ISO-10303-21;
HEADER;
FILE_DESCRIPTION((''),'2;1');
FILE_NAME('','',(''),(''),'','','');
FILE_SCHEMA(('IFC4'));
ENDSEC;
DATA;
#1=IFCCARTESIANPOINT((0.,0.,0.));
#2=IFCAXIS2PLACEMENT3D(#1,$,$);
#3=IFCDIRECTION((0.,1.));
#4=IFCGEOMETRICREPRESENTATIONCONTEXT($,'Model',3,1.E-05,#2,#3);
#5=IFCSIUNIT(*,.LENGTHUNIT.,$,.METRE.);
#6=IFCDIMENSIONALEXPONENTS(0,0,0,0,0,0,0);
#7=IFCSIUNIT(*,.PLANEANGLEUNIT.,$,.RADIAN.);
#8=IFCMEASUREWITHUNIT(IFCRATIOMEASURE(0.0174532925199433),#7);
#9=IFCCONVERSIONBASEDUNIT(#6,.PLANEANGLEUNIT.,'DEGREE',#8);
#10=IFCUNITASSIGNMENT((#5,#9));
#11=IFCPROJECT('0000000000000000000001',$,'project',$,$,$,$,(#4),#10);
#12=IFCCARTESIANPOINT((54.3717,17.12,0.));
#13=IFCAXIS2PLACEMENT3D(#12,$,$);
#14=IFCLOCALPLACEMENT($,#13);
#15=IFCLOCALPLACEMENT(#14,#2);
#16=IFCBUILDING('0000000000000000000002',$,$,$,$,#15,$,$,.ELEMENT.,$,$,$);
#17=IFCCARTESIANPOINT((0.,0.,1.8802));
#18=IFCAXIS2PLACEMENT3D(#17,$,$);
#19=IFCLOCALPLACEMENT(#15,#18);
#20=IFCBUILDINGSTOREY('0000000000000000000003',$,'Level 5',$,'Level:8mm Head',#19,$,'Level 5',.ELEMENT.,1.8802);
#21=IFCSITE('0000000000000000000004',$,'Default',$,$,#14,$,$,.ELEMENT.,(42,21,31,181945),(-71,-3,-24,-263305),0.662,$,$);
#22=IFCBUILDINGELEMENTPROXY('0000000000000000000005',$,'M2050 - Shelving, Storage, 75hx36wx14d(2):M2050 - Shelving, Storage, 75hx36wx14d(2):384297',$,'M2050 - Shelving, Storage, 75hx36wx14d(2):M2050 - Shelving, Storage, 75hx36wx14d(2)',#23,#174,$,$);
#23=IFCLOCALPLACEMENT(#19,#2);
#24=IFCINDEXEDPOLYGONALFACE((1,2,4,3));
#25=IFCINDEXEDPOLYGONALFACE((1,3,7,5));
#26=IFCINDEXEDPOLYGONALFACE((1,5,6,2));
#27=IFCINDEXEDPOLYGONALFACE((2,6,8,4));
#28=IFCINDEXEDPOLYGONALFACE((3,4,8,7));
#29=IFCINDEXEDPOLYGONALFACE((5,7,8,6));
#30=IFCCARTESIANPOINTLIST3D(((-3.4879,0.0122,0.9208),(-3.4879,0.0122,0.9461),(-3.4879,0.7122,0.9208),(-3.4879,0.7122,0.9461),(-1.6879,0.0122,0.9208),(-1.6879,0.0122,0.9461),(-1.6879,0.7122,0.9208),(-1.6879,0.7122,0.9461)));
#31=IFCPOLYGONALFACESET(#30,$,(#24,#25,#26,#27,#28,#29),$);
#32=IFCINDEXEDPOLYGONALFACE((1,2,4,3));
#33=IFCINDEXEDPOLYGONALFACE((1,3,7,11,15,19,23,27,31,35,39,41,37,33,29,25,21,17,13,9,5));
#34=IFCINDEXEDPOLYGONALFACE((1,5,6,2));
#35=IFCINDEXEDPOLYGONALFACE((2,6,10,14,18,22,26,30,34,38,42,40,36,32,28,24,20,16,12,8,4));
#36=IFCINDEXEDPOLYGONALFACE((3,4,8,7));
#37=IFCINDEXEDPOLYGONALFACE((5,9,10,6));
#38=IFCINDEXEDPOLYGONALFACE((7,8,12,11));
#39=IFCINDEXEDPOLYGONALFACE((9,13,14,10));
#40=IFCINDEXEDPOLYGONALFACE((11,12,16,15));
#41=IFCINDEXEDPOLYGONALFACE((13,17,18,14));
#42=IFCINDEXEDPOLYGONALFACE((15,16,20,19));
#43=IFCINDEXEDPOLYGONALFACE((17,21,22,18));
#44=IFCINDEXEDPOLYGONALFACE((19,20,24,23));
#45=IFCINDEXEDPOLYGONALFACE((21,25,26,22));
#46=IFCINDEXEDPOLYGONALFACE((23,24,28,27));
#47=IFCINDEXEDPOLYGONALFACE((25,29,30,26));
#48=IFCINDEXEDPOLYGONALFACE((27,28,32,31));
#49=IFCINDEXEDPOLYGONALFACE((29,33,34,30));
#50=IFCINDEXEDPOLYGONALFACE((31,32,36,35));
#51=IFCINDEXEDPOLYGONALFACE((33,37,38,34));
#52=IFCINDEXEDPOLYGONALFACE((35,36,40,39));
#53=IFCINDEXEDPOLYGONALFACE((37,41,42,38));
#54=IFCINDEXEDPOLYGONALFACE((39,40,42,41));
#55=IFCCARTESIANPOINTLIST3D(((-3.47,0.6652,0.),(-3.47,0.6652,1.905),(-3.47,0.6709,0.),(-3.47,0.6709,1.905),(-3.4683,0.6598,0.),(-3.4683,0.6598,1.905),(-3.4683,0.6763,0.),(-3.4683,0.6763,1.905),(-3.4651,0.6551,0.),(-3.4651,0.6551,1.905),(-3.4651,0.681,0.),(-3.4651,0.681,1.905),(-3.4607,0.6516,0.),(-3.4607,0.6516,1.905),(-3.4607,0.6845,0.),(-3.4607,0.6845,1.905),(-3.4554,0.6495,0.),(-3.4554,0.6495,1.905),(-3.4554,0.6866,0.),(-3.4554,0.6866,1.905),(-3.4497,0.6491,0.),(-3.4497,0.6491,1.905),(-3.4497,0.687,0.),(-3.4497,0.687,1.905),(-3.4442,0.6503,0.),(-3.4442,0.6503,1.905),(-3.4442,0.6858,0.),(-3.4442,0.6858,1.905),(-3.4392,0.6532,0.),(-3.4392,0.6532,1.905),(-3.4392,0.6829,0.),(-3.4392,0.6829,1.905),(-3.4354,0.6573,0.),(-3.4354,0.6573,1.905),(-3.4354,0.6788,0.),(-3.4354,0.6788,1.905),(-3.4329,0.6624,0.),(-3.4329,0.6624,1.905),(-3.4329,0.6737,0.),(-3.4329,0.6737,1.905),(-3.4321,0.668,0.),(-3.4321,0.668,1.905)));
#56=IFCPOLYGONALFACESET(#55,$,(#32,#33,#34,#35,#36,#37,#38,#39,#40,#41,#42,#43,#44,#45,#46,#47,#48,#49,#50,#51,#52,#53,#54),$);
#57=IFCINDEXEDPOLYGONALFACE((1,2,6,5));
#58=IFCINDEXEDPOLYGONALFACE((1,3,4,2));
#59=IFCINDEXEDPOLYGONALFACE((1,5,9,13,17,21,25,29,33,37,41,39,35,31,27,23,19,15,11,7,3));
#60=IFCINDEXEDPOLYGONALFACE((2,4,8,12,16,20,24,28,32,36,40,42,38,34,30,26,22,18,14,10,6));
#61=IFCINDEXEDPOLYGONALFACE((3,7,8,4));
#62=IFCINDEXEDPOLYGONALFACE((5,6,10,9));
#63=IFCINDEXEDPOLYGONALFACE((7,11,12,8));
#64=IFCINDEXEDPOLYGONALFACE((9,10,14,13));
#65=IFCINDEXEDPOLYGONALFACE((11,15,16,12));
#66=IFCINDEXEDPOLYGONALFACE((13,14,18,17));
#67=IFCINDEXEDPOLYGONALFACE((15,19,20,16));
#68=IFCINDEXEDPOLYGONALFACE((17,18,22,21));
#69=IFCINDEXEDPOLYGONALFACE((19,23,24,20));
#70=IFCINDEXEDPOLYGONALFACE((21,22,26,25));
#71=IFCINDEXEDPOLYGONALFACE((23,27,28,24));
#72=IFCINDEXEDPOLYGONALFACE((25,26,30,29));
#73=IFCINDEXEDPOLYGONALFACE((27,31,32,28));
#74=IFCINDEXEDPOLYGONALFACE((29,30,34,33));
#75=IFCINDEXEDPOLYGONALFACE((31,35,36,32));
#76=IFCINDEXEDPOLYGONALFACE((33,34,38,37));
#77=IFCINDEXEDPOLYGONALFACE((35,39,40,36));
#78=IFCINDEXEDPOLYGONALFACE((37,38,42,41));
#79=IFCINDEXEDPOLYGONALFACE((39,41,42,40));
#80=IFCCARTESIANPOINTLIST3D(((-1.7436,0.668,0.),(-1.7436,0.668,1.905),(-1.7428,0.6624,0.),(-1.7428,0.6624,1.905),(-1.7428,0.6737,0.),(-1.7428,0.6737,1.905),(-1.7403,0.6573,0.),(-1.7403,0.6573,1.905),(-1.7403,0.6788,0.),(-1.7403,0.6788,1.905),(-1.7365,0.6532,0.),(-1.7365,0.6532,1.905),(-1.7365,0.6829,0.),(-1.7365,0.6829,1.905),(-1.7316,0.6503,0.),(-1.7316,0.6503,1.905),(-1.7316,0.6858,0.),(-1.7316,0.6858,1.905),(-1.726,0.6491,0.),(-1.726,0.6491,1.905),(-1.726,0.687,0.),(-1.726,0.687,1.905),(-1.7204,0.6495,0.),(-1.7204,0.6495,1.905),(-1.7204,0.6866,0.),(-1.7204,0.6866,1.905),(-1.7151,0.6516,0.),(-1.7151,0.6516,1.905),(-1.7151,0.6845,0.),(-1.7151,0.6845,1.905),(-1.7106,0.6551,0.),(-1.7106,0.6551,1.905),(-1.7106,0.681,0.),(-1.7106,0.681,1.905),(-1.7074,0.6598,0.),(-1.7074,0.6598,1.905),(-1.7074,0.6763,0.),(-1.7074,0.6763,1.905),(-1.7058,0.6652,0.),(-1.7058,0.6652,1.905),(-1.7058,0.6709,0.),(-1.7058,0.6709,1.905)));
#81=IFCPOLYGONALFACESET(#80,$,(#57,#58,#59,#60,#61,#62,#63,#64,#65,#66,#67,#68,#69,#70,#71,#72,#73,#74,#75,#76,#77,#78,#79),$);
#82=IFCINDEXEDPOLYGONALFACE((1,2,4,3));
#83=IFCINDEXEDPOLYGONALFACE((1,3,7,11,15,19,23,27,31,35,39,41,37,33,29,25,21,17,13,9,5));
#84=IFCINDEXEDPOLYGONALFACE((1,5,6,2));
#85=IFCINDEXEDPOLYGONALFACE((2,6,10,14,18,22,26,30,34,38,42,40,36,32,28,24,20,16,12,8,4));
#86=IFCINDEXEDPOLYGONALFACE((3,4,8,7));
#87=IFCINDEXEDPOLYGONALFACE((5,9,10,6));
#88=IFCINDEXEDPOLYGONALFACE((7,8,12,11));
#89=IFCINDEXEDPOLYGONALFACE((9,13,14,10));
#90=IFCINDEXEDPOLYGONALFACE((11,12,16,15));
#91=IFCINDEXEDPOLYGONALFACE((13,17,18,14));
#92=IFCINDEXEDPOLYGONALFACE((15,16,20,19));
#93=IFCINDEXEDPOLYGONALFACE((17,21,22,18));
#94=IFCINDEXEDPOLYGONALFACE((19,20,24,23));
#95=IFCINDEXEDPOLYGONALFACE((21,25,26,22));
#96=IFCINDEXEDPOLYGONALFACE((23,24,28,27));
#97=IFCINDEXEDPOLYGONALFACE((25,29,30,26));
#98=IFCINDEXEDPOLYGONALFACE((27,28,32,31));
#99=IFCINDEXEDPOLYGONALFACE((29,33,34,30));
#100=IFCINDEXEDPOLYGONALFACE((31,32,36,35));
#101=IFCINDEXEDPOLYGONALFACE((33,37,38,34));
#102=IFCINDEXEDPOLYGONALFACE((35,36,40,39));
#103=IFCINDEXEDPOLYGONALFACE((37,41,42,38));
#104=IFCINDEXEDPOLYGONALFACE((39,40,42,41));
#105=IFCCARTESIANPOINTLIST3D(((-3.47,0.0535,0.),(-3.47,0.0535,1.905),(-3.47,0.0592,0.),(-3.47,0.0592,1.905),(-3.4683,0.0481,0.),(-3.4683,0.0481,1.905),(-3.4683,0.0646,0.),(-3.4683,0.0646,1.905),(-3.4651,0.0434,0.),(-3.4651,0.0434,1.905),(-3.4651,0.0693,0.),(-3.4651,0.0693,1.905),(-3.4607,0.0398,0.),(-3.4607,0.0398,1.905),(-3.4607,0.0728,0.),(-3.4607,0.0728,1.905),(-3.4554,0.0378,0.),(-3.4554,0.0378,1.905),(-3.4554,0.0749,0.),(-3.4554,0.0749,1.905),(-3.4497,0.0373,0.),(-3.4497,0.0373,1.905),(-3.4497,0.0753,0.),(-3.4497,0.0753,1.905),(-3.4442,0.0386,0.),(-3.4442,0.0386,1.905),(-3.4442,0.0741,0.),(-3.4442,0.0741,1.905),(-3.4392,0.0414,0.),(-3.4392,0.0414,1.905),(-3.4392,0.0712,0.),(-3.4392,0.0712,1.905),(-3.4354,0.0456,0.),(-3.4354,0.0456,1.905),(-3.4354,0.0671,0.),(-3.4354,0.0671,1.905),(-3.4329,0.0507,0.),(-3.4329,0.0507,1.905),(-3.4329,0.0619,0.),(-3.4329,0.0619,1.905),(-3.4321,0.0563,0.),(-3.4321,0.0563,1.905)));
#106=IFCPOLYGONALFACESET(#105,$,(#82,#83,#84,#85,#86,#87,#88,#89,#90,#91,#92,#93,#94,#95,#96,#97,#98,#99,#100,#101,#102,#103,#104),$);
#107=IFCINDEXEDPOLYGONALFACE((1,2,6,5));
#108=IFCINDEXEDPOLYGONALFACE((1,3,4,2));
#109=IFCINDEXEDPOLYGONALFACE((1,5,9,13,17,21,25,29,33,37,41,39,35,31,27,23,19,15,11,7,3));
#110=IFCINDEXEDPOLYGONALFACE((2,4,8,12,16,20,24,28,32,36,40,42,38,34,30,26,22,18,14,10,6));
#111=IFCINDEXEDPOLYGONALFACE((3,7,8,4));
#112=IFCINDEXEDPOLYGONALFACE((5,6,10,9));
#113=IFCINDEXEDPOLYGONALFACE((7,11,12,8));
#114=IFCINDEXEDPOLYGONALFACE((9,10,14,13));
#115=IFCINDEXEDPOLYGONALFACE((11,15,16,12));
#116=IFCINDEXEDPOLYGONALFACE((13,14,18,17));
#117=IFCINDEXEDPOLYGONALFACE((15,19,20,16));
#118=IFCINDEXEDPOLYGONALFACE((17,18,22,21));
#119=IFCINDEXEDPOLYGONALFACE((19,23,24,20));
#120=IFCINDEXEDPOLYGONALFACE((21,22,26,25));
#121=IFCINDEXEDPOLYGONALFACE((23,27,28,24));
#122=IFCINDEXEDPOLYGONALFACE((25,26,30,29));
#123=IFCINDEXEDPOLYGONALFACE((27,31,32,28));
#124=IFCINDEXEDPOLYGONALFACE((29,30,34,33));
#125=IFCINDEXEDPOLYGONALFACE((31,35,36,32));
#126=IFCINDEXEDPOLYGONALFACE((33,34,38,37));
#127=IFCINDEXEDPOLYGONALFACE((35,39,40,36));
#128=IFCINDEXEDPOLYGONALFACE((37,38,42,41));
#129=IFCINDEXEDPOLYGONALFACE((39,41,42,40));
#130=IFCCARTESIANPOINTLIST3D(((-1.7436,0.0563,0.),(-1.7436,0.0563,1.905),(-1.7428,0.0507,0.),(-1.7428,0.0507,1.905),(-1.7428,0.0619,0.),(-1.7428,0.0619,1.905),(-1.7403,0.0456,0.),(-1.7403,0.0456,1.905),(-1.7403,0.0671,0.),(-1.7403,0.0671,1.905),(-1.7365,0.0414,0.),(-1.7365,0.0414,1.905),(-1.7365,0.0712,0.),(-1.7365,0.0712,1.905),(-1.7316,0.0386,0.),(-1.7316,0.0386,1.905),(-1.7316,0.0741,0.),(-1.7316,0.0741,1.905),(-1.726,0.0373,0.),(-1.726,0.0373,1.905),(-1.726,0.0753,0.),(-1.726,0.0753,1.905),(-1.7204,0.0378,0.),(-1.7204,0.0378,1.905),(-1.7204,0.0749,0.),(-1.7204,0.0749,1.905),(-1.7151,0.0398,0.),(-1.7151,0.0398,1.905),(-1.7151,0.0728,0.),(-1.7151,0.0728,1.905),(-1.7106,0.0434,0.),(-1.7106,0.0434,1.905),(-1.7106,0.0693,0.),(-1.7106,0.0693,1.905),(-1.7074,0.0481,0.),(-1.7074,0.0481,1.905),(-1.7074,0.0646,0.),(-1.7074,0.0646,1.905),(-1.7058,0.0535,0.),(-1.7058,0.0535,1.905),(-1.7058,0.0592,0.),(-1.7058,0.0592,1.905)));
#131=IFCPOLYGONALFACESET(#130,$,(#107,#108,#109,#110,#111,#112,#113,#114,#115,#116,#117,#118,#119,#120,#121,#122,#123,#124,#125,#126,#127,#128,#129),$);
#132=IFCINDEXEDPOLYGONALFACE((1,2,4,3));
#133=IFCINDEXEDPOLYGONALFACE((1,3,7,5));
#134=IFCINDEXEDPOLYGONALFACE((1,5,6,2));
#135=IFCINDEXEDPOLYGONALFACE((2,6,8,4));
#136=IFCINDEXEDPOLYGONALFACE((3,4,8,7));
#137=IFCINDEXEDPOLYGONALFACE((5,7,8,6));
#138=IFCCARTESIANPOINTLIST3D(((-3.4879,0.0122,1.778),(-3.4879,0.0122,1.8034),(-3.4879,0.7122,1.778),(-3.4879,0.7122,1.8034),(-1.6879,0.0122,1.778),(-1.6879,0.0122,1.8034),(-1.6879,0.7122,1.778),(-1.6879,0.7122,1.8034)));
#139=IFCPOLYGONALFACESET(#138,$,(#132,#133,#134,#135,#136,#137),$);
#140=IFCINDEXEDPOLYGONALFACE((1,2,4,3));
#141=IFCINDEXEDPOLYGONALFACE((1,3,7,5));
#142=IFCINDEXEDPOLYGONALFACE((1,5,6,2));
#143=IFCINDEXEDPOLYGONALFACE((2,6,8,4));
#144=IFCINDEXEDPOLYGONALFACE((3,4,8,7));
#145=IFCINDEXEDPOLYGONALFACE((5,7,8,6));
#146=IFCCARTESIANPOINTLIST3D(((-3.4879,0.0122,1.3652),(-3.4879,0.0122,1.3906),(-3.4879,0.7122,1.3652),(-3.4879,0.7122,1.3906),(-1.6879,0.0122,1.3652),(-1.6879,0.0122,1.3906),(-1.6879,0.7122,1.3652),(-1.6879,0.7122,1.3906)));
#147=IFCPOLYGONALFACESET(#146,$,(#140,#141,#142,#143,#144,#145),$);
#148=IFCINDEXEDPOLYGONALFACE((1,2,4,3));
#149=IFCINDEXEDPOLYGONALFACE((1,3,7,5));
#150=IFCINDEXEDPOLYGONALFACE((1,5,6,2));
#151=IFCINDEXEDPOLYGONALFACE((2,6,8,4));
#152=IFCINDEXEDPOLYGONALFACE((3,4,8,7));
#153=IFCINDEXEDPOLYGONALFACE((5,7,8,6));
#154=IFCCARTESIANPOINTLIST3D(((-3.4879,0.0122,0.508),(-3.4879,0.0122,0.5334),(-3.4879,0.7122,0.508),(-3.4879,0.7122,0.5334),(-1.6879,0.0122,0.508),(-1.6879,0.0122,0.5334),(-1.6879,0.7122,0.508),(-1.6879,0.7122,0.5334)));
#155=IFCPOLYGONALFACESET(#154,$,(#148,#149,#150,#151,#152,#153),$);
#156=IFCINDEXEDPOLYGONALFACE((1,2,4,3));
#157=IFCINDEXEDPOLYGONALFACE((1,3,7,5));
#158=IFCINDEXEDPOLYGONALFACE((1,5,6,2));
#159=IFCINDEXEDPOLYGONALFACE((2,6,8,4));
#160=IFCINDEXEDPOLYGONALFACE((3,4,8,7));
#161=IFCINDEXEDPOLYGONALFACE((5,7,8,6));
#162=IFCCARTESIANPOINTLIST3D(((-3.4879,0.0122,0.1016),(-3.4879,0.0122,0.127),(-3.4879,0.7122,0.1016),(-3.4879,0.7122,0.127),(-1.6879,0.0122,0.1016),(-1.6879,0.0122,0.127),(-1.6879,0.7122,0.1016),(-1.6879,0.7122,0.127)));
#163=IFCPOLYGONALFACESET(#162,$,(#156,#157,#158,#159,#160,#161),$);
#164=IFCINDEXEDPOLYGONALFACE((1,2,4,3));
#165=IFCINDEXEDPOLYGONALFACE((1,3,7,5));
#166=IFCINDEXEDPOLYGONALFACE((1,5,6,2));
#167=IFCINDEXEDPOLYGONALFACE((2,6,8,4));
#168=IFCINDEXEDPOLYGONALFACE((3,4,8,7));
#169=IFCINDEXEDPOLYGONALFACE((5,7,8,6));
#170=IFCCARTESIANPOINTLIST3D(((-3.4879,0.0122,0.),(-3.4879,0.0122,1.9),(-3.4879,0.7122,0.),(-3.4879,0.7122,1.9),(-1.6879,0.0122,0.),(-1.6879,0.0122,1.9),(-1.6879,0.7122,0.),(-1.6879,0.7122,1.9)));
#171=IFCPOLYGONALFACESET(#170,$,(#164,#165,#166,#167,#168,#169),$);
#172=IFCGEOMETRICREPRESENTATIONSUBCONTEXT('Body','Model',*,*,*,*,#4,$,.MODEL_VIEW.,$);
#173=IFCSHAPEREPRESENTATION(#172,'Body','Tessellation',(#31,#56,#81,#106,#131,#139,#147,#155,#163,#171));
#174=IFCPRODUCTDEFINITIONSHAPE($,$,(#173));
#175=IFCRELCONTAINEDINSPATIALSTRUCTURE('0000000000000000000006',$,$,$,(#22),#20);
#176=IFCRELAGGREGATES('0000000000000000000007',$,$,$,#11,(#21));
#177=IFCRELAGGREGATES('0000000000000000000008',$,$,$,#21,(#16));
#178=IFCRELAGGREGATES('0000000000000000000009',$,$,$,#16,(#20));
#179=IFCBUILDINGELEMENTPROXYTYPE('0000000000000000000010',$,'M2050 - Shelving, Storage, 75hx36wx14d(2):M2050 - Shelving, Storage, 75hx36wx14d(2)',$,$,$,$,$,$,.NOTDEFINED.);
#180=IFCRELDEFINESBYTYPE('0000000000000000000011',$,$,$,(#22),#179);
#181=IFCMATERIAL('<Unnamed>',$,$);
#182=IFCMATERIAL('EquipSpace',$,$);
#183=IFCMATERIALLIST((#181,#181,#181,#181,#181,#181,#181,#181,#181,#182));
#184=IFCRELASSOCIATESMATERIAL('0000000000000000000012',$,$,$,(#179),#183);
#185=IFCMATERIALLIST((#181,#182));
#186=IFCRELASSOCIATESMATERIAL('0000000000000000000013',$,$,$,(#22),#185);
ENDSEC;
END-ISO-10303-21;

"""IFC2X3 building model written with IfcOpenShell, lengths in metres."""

from ifc_helpers import new_model, entity, si_unit, converted_unit, direction, frame, frame_2d, origin, origin_2d_with_axis, place, context, subcontext, project, spatial, rectangle, circle, extrude, source, transform, mapped, material, material_list, type_object, type_shapes, element, save


model = new_model("IFC2X3")

# Units and contexts
model_context = context("Model", 3, precision=1e-05, world=origin(), true_north=direction((0.0, 1.0)))
body_context = subcontext(model_context, "Body", "Model", "MODEL_VIEW")
ifc_project = project(units=[si_unit("LENGTHUNIT", "METRE"), converted_unit("PLANEANGLEUNIT", "DEGREE", entity("IfcRatioMeasure", 0.0174532925199433), si_unit("PLANEANGLEUNIT", "RADIAN"), dimensions=[0, 0, 0, 0, 0, 0, 0])], contexts=[model_context])

# Site, building, storey
site_placement = place(None, frame((54.3717, 17.12, 0.0)))
site = spatial("IfcSite", under=ifc_project, at=site_placement, Name="Default", CompositionType="ELEMENT", RefLatitude=(42, 21, 31, 181945), RefLongitude=(-71, -3, -24, -263305), RefElevation=0.662)
building_placement = place(site_placement, origin())
building = spatial("IfcBuilding", under=site, at=building_placement, CompositionType="ELEMENT")
storey_placement = place(building_placement, frame((0.0, 0.0, 1.8802)))
storey = spatial("IfcBuildingStorey", under=building, at=storey_placement, Name="Level 5", ObjectType="Level:8mm Head", LongName="Level 5", CompositionType="ELEMENT", Elevation=1.8802)

# Building element proxy
ifc_material_1 = material(Name="<Unnamed>")
ifc_material_2 = material(Name="EquipSpace")
ifc_material_list_1 = material_list([ifc_material_1, ifc_material_1, ifc_material_1, ifc_material_1, ifc_material_1, ifc_material_1, ifc_material_1, ifc_material_1, ifc_material_1, ifc_material_2])
building_element_proxy_type = type_object("IfcBuildingElementProxyType", Name="M2050 - Shelving, Storage, 75hx36wx14d(2):M2050 - Shelving, Storage, 75hx36wx14d(2)", PredefinedType="NOTDEFINED", material=ifc_material_list_1)
shared_shape = source(origin(), body_context, "Body", "SweptSolid", [
    extrude(rectangle(XDim=1.8, YDim=0.7, at=origin_2d_with_axis()), frame((0.0, 0.0, 0.9207), z_axis=(0.0, 0.0, 1.0), x_axis=(-1.0, 0.0, 0.0)), (0.0, 0.0, 1.0), 0.0254),
    extrude(circle(Radius=0.0191, at=origin_2d_with_axis()), frame((0.8633, -0.3059, 0.0), z_axis=(0.0, 0.0, 1.0), x_axis=(-1.0, 0.0, 0.0)), (0.0, 0.0, 1.0), 1.905),
    extrude(circle(Radius=0.0191, at=origin_2d_with_axis()), frame((-0.8633, -0.3059, 0.0)), (0.0, 0.0, 1.0), 1.905),
    extrude(circle(Radius=0.0191, at=origin_2d_with_axis()), frame((0.8633, 0.3059, 0.0), z_axis=(0.0, 0.0, 1.0), x_axis=(-1.0, 0.0, 0.0)), (0.0, 0.0, 1.0), 1.905),
    extrude(circle(Radius=0.0191, at=origin_2d_with_axis()), frame((-0.8633, 0.3059, 0.0)), (0.0, 0.0, 1.0), 1.905),
    extrude(rectangle(XDim=1.8, YDim=0.7, at=origin_2d_with_axis()), frame((0.0, 0.0, 1.778), z_axis=(0.0, 0.0, 1.0), x_axis=(-1.0, 0.0, 0.0)), (0.0, 0.0, 1.0), 0.0254),
    extrude(rectangle(XDim=1.8, YDim=0.7, at=origin_2d_with_axis()), frame((0.0, 0.0, 1.3653), z_axis=(0.0, 0.0, 1.0), x_axis=(-1.0, 0.0, 0.0)), (0.0, 0.0, 1.0), 0.0254),
    extrude(rectangle(XDim=1.8, YDim=0.7, at=origin_2d_with_axis()), frame((0.0, 0.0, 0.508), z_axis=(0.0, 0.0, 1.0), x_axis=(-1.0, 0.0, 0.0)), (0.0, 0.0, 1.0), 0.0254),
    extrude(rectangle(XDim=1.8, YDim=0.7, at=origin_2d_with_axis()), frame((0.0, 0.0, 0.1016), z_axis=(0.0, 0.0, 1.0), x_axis=(-1.0, 0.0, 0.0)), (0.0, 0.0, 1.0), 0.0254),
    extrude(rectangle(XDim=0.7, YDim=1.8, at=frame_2d((0.0, 0.18), x_axis=(1.0, 0.0))), frame((-0.18, 0.0, 0.0), z_axis=(0.0, 0.0, 1.0), x_axis=(0.0, -1.0, 0.0)), (0.0, 0.0, 1.0), 1.9),
])
type_shapes(building_element_proxy_type, [shared_shape])
ifc_material_list_2 = material_list([ifc_material_1, ifc_material_2])
proxy_1_placement = place(storey_placement, frame((-2.5879, 0.3622, 0.0), z_axis=(0.0, 0.0, 1.0), x_axis=(-1.0, 0.0, 0.0)))
element("IfcBuildingElementProxy", 1, at=proxy_1_placement, inside=storey, type_object=building_element_proxy_type, material=ifc_material_list_2, Name="M2050 - Shelving, Storage, 75hx36wx14d(2):M2050 - Shelving, Storage, 75hx36wx14d(2):384297", ObjectType="M2050 - Shelving, Storage, 75hx36wx14d(2):M2050 - Shelving, Storage, 75hx36wx14d(2)", context=body_context, shape_type="MappedRepresentation", body=[
    mapped(shared_shape, transform((0.0, 0.0, 0.0), scale=1.0)),
])

save(model, "model.ifc")
